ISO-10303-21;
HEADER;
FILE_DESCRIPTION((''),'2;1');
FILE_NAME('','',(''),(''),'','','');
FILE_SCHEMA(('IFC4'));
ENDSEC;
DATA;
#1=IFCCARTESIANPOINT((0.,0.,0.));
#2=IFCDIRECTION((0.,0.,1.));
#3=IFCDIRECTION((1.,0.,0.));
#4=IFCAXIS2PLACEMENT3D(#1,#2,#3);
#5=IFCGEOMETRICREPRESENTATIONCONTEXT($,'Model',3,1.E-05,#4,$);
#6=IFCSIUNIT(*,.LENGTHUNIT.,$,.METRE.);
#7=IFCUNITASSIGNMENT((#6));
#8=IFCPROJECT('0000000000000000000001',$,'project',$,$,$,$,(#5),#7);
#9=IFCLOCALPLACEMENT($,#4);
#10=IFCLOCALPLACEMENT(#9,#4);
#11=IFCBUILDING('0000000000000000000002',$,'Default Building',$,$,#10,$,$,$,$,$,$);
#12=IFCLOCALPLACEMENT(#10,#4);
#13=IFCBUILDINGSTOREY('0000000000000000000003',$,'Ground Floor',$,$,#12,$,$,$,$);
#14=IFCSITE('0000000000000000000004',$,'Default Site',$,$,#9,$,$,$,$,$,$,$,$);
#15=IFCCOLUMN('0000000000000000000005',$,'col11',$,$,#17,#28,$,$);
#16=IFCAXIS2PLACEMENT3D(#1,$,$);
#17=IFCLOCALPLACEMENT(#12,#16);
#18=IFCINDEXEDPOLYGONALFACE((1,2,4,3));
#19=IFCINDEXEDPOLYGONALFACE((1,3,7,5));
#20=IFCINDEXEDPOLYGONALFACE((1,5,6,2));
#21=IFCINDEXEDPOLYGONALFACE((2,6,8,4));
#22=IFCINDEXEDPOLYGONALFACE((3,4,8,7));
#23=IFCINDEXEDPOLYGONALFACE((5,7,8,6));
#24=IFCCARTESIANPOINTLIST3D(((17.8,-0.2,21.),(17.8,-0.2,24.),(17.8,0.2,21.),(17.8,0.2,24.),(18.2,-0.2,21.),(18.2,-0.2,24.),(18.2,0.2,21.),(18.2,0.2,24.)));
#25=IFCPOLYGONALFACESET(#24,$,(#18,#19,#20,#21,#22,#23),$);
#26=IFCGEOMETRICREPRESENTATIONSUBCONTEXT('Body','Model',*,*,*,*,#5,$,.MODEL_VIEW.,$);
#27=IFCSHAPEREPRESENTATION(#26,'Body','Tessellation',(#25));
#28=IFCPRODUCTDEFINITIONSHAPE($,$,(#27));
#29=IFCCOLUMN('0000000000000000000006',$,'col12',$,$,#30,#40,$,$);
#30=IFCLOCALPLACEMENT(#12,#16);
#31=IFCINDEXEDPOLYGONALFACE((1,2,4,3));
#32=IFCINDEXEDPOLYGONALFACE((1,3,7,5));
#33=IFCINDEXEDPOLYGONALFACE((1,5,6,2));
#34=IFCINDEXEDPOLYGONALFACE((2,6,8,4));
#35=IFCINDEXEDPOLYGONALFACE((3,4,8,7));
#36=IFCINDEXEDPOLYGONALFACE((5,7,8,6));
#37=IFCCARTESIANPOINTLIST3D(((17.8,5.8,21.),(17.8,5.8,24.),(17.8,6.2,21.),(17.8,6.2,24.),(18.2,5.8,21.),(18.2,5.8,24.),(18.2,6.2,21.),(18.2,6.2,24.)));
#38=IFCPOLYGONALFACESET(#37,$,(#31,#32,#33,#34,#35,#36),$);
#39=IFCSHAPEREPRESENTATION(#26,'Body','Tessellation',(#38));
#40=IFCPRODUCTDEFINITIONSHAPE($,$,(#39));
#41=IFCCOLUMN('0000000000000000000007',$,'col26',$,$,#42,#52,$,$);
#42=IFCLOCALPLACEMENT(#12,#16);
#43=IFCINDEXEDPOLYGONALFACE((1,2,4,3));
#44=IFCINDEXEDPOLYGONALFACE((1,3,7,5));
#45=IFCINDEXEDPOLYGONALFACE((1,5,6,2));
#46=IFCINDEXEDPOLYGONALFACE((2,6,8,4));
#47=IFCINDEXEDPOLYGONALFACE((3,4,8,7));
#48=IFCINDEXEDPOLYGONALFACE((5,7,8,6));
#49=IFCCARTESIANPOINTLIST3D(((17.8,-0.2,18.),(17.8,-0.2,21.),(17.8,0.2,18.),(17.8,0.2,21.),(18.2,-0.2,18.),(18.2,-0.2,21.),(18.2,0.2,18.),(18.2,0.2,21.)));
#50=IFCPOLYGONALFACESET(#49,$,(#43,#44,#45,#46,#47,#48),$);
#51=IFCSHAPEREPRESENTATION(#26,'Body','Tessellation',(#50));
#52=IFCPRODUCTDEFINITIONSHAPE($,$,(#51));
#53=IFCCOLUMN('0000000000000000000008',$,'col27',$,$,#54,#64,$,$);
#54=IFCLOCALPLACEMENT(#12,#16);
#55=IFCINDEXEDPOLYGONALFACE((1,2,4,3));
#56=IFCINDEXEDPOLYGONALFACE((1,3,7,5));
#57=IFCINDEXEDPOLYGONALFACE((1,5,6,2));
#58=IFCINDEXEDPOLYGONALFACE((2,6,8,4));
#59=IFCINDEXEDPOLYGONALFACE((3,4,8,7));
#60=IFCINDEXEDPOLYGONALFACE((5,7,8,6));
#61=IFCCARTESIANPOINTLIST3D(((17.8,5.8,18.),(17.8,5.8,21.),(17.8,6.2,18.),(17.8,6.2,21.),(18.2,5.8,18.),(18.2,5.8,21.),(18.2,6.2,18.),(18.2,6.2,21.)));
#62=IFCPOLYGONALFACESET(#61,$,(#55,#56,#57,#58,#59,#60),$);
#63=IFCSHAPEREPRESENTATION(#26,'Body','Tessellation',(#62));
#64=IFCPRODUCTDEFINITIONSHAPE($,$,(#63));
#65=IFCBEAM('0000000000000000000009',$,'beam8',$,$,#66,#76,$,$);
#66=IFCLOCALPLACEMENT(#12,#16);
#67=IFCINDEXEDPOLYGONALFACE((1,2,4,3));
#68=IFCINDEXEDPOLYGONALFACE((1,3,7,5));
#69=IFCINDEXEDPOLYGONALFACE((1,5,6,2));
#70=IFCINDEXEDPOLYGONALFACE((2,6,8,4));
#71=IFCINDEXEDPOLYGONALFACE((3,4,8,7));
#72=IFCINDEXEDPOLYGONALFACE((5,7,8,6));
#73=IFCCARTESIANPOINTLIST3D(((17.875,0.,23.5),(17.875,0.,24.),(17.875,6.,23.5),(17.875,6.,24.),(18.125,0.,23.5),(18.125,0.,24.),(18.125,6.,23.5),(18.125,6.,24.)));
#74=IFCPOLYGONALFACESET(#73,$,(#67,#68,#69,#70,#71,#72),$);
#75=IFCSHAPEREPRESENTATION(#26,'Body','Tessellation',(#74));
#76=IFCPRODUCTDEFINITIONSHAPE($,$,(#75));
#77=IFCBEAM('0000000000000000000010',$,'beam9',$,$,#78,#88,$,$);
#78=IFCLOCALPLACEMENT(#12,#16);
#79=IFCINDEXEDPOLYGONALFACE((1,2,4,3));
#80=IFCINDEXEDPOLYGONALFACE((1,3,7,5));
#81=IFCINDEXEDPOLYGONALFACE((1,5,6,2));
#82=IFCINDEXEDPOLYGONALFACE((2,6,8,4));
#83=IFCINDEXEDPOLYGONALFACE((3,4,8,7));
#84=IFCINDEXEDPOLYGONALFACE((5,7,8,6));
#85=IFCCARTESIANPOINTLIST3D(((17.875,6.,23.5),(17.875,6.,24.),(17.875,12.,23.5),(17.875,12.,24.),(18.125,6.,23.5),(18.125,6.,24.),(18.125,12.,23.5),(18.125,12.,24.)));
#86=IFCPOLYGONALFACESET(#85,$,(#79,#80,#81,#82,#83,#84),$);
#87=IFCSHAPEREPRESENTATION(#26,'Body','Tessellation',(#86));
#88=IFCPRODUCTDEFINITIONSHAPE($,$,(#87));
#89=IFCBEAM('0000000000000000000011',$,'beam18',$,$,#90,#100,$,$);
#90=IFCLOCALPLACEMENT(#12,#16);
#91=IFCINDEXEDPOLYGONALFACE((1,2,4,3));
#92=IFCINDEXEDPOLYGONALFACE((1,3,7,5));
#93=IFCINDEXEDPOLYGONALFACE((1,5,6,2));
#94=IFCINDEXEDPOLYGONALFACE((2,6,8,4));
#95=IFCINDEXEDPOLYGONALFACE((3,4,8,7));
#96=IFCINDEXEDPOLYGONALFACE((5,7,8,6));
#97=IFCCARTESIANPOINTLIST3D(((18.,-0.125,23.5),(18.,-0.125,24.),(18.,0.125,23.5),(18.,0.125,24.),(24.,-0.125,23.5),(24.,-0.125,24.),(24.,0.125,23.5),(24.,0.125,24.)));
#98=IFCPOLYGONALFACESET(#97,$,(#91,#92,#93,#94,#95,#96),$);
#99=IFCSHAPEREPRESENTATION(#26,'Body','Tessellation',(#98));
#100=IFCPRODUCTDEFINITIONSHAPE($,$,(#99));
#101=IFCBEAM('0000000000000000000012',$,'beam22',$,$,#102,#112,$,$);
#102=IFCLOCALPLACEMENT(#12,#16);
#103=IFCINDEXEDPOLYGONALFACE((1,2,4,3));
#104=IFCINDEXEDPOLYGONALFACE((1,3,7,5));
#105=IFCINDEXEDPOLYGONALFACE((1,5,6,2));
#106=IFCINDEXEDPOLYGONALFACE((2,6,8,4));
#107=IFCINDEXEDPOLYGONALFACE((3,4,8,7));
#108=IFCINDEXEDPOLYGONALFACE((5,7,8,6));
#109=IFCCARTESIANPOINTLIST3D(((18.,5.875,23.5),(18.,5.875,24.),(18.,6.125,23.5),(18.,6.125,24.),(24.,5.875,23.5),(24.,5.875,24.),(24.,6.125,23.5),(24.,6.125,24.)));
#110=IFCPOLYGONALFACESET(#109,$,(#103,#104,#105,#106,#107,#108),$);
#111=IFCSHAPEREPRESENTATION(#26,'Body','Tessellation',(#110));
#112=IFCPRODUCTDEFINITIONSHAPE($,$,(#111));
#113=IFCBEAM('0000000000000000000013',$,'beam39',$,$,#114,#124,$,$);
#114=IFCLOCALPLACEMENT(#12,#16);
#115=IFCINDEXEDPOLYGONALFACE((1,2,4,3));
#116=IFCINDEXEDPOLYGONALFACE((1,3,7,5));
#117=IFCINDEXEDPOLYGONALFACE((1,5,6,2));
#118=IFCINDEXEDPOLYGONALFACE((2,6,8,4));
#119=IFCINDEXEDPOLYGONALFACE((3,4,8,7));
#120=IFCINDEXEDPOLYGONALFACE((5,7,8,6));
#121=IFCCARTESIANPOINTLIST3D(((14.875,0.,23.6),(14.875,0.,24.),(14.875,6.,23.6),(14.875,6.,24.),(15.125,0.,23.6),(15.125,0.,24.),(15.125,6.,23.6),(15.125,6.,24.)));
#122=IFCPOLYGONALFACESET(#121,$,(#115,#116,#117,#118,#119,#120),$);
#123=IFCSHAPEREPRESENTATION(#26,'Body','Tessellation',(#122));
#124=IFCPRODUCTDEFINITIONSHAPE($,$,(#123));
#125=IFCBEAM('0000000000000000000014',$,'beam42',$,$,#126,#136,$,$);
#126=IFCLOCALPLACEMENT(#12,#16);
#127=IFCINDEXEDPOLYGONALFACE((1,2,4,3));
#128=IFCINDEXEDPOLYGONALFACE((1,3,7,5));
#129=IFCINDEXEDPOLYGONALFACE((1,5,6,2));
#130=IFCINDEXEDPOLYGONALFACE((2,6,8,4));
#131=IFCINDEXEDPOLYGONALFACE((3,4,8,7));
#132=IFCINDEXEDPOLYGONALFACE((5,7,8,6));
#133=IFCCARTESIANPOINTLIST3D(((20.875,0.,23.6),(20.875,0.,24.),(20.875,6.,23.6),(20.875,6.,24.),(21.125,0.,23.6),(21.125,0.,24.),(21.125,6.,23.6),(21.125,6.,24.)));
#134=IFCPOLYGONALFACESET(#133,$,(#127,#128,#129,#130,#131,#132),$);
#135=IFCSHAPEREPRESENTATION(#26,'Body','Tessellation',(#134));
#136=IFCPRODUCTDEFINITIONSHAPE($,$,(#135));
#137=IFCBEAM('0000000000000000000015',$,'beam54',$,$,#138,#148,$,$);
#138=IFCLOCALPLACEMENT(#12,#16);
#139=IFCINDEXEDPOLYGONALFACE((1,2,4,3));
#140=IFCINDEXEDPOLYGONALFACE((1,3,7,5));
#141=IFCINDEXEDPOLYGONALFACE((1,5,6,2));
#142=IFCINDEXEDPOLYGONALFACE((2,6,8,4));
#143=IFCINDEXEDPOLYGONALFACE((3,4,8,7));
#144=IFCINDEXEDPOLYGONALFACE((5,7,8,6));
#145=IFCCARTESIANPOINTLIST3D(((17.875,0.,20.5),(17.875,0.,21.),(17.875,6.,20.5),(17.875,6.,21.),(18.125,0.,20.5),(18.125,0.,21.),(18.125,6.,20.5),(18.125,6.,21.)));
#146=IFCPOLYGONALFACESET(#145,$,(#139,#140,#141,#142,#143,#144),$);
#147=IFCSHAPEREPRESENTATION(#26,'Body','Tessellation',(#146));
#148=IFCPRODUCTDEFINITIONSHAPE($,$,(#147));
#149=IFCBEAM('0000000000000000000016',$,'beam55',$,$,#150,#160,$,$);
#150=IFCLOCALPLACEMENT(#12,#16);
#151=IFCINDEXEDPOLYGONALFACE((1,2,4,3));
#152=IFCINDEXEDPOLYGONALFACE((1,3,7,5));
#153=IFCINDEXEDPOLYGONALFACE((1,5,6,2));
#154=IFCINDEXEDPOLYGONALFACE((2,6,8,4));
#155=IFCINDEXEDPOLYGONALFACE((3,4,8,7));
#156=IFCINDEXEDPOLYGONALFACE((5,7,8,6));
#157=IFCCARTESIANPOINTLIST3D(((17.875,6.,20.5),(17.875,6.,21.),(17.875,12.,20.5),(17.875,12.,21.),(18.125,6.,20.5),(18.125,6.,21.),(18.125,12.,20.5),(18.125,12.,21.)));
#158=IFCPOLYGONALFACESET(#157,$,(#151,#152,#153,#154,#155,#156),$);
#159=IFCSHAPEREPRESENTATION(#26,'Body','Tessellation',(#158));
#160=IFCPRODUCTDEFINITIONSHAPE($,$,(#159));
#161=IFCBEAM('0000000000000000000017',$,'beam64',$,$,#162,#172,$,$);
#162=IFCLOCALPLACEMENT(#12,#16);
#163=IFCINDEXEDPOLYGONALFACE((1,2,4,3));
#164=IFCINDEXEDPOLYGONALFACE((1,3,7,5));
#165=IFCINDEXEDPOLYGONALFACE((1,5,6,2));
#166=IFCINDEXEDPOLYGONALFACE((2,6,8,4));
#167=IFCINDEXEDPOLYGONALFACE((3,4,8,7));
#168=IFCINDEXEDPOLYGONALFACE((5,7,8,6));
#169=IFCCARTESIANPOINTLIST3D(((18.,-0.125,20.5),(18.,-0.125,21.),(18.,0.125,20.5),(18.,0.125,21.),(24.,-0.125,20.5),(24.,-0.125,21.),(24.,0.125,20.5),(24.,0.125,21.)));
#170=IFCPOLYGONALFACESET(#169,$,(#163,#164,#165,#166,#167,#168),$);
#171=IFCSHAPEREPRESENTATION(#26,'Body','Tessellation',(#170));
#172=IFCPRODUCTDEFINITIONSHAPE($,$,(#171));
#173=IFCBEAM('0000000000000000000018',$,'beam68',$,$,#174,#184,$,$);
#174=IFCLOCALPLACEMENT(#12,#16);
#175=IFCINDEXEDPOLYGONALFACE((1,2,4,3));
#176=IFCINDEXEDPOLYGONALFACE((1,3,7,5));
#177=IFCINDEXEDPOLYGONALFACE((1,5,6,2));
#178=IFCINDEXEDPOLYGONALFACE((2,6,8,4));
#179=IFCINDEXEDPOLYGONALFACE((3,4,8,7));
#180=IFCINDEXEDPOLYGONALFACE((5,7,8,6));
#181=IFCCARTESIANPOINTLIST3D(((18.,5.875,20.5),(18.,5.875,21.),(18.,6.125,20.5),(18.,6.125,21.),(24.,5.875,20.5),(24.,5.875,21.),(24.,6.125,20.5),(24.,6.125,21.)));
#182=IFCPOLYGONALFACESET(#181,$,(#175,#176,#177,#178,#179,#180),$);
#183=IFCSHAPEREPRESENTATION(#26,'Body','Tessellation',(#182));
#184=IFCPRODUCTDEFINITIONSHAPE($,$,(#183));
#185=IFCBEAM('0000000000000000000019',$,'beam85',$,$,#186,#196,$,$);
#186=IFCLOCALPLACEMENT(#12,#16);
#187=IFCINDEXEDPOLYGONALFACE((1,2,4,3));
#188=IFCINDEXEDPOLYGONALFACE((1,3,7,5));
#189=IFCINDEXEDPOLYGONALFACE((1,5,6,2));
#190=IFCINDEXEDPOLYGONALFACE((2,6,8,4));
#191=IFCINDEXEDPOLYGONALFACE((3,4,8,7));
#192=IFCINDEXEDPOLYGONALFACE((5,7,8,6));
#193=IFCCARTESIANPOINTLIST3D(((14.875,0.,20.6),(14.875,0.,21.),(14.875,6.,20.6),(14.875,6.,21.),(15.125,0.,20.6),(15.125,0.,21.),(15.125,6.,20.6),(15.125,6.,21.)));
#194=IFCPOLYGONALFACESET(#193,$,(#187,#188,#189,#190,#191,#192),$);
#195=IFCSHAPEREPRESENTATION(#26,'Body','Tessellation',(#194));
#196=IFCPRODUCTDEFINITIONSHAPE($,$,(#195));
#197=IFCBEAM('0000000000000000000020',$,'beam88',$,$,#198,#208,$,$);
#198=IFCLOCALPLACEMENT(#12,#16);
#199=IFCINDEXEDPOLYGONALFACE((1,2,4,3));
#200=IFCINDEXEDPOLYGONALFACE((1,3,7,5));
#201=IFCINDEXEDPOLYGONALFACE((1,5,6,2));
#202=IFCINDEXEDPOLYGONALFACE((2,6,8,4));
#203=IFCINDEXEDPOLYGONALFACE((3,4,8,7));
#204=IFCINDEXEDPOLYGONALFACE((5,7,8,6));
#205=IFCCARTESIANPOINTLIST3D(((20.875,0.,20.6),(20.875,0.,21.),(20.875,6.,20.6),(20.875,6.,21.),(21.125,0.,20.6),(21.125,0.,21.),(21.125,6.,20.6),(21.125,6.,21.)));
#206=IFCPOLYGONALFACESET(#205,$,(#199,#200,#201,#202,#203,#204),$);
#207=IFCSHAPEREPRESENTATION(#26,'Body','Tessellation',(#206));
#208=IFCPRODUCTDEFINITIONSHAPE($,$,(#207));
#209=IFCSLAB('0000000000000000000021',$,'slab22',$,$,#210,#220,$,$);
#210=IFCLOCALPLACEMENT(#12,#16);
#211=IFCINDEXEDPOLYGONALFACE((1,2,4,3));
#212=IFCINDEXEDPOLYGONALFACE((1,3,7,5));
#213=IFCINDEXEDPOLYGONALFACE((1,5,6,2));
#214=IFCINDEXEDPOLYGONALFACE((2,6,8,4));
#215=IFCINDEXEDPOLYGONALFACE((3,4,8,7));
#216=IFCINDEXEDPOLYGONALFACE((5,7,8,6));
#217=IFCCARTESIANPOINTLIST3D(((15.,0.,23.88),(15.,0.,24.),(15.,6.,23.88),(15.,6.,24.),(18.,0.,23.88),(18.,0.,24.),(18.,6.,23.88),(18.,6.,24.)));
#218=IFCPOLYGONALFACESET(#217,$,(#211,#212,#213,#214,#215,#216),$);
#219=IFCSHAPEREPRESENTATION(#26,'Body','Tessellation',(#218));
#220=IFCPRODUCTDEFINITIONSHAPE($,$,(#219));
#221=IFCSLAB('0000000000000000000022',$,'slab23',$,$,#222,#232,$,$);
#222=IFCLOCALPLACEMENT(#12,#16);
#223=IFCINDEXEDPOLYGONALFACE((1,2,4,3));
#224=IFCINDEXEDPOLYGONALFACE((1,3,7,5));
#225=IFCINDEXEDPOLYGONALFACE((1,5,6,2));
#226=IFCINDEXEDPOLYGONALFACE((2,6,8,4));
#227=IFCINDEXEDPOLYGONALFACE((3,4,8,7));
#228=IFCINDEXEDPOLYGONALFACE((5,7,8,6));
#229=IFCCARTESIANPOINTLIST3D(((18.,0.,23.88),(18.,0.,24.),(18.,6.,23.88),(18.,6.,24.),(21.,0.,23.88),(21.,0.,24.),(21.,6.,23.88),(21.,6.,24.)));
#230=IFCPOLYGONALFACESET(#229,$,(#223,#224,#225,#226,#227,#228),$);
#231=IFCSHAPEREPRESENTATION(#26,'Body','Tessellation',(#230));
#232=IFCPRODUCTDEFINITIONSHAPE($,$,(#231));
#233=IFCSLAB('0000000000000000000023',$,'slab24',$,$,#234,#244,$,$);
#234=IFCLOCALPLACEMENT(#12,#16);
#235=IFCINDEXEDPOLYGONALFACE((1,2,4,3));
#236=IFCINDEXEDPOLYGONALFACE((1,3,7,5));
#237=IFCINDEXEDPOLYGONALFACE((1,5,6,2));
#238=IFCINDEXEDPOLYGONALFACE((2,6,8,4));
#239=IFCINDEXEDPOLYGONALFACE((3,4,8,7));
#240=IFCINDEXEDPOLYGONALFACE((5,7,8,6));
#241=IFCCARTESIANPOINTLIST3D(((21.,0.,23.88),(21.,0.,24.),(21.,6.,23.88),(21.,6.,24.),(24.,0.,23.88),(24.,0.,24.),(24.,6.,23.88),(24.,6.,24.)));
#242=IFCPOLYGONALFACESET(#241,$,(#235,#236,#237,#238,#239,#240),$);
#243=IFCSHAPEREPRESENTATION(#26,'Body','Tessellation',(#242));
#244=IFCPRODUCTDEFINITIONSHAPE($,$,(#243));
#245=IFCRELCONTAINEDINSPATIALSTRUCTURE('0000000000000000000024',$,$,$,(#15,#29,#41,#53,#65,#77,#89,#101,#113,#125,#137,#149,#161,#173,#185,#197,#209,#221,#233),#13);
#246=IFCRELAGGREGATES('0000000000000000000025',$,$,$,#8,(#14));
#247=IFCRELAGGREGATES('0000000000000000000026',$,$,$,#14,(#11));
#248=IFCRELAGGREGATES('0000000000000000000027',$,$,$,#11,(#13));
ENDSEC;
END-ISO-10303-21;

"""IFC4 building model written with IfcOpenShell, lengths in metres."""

from ifc_helpers import new_model, si_unit, frame, origin_with_axes, place, context, subcontext, project, spatial, indexed_curve, outline, extrude, element, save


model = new_model("IFC4")

# Units and contexts
model_context = context("Model", 3, precision=1e-05, world=origin_with_axes())
body_context = subcontext(model_context, "Body", "Model", "MODEL_VIEW")
ifc_project = project(units=[si_unit("LENGTHUNIT", "METRE")], contexts=[model_context])

# Site, building, storey
site_placement = place(None, origin_with_axes())
site = spatial("IfcSite", under=ifc_project, at=site_placement, Name="Default Site")
building_placement = place(site_placement, origin_with_axes())
building = spatial("IfcBuilding", under=site, at=building_placement, Name="Default Building")
storey_placement = place(building_placement, origin_with_axes())
storey = spatial("IfcBuildingStorey", under=building, at=storey_placement, Name="Ground Floor")

# Columns
for number, where, z_axis, x_axis, name in (
    (1, (17.8, -0.2, 21.0), (0.0, 0.0, 1.0), (1.0, 0.0, 0.0), "col11"),
    (2, (17.8, 5.8, 21.0), (0.0, 0.0, 1.0), (1.0, 0.0, 0.0), "col12"),
    (3, (17.8, -0.2, 18.0), (0.0, 0.0, 1.0), (1.0, 0.0, 0.0), "col26"),
    (4, (17.8, 5.8, 18.0), (0.0, 0.0, 1.0), (1.0, 0.0, 0.0), "col27"),
):
    element("IfcColumn", number, at=place(storey_placement, frame(where, z_axis=z_axis, x_axis=x_axis)), inside=storey, Name=name, context=body_context, shape_type="SweptSolid", body=[
        extrude(outline(indexed_curve([(0.0, 0.0), (0.0, 0.4), (0.4, 0.4), (0.4, 0.0), (0.0, 0.0)], self_intersect=False)), origin_with_axes(), (0.0, 0.0, 1.0), 3.0),
    ])

# Beams
for number, where, z_axis, x_axis, name in (
    (5, (18.125, 0.0, 23.5), (0.0, 0.0, 1.0), (0.0, 1.0, 0.0), "beam8"),
    (6, (18.125, 6.0, 23.5), (0.0, 0.0, 1.0), (0.0, 1.0, 0.0), "beam9"),
    (7, (18.0, -0.125, 23.5), (0.0, 0.0, 1.0), (1.0, 0.0, 0.0), "beam18"),
    (8, (18.0, 5.875, 23.5), (0.0, 0.0, 1.0), (1.0, 0.0, 0.0), "beam22"),
):
    element("IfcBeam", number, at=place(storey_placement, frame(where, z_axis=z_axis, x_axis=x_axis)), inside=storey, Name=name, context=body_context, shape_type="SweptSolid", body=[
        extrude(outline(indexed_curve([(0.0, 0.0), (0.0, 0.25), (6.0, 0.25), (6.0, 0.0), (0.0, 0.0)], self_intersect=False)), origin_with_axes(), (0.0, 0.0, 1.0), 0.5),
    ])
for number, where, z_axis, x_axis, name in (
    (9, (14.875, 6.0, 23.6), (0.0, 0.0, 1.0), (0.0, -1.0, 0.0), "beam39"),
    (10, (20.875, 6.0, 23.6), (0.0, 0.0, 1.0), (0.0, -1.0, 0.0), "beam42"),
):
    element("IfcBeam", number, at=place(storey_placement, frame(where, z_axis=z_axis, x_axis=x_axis)), inside=storey, Name=name, context=body_context, shape_type="SweptSolid", body=[
        extrude(outline(indexed_curve([(0.0, 0.0), (0.0, 0.25), (6.0, 0.25), (6.0, 0.0), (0.0, 0.0)], self_intersect=False)), origin_with_axes(), (0.0, 0.0, 1.0), 0.4),
    ])
for number, where, z_axis, x_axis, name in (
    (11, (18.125, 0.0, 20.5), (0.0, 0.0, 1.0), (0.0, 1.0, 0.0), "beam54"),
    (12, (18.125, 6.0, 20.5), (0.0, 0.0, 1.0), (0.0, 1.0, 0.0), "beam55"),
    (13, (18.0, -0.125, 20.5), (0.0, 0.0, 1.0), (1.0, 0.0, 0.0), "beam64"),
    (14, (18.0, 5.875, 20.5), (0.0, 0.0, 1.0), (1.0, 0.0, 0.0), "beam68"),
):
    element("IfcBeam", number, at=place(storey_placement, frame(where, z_axis=z_axis, x_axis=x_axis)), inside=storey, Name=name, context=body_context, shape_type="SweptSolid", body=[
        extrude(outline(indexed_curve([(0.0, 0.0), (0.0, 0.25), (6.0, 0.25), (6.0, 0.0), (0.0, 0.0)], self_intersect=False)), origin_with_axes(), (0.0, 0.0, 1.0), 0.5),
    ])
for number, where, z_axis, x_axis, name in (
    (15, (14.875, 6.0, 20.6), (0.0, 0.0, 1.0), (0.0, -1.0, 0.0), "beam85"),
    (16, (20.875, 6.0, 20.6), (0.0, 0.0, 1.0), (0.0, -1.0, 0.0), "beam88"),
):
    element("IfcBeam", number, at=place(storey_placement, frame(where, z_axis=z_axis, x_axis=x_axis)), inside=storey, Name=name, context=body_context, shape_type="SweptSolid", body=[
        extrude(outline(indexed_curve([(0.0, 0.0), (0.0, 0.25), (6.0, 0.25), (6.0, 0.0), (0.0, 0.0)], self_intersect=False)), origin_with_axes(), (0.0, 0.0, 1.0), 0.4),
    ])

# Slabs
for number, where, z_axis, x_axis, name in (
    (17, (15.0, 0.0, 23.88), (0.0, 0.0, 1.0), (1.0, 0.0, 0.0), "slab22"),
    (18, (18.0, 0.0, 23.88), (0.0, 0.0, 1.0), (1.0, 0.0, 0.0), "slab23"),
    (19, (21.0, 0.0, 23.88), (0.0, 0.0, 1.0), (1.0, 0.0, 0.0), "slab24"),
):
    element("IfcSlab", number, at=place(storey_placement, frame(where, z_axis=z_axis, x_axis=x_axis)), inside=storey, Name=name, context=body_context, shape_type="SweptSolid", body=[
        extrude(outline(indexed_curve([(0.0, 0.0), (0.0, 6.0), (3.0, 6.0), (3.0, 0.0), (0.0, 0.0)], self_intersect=False)), origin_with_axes(), (0.0, 0.0, 1.0), 0.12),
    ])

save(model, "model.ifc")
